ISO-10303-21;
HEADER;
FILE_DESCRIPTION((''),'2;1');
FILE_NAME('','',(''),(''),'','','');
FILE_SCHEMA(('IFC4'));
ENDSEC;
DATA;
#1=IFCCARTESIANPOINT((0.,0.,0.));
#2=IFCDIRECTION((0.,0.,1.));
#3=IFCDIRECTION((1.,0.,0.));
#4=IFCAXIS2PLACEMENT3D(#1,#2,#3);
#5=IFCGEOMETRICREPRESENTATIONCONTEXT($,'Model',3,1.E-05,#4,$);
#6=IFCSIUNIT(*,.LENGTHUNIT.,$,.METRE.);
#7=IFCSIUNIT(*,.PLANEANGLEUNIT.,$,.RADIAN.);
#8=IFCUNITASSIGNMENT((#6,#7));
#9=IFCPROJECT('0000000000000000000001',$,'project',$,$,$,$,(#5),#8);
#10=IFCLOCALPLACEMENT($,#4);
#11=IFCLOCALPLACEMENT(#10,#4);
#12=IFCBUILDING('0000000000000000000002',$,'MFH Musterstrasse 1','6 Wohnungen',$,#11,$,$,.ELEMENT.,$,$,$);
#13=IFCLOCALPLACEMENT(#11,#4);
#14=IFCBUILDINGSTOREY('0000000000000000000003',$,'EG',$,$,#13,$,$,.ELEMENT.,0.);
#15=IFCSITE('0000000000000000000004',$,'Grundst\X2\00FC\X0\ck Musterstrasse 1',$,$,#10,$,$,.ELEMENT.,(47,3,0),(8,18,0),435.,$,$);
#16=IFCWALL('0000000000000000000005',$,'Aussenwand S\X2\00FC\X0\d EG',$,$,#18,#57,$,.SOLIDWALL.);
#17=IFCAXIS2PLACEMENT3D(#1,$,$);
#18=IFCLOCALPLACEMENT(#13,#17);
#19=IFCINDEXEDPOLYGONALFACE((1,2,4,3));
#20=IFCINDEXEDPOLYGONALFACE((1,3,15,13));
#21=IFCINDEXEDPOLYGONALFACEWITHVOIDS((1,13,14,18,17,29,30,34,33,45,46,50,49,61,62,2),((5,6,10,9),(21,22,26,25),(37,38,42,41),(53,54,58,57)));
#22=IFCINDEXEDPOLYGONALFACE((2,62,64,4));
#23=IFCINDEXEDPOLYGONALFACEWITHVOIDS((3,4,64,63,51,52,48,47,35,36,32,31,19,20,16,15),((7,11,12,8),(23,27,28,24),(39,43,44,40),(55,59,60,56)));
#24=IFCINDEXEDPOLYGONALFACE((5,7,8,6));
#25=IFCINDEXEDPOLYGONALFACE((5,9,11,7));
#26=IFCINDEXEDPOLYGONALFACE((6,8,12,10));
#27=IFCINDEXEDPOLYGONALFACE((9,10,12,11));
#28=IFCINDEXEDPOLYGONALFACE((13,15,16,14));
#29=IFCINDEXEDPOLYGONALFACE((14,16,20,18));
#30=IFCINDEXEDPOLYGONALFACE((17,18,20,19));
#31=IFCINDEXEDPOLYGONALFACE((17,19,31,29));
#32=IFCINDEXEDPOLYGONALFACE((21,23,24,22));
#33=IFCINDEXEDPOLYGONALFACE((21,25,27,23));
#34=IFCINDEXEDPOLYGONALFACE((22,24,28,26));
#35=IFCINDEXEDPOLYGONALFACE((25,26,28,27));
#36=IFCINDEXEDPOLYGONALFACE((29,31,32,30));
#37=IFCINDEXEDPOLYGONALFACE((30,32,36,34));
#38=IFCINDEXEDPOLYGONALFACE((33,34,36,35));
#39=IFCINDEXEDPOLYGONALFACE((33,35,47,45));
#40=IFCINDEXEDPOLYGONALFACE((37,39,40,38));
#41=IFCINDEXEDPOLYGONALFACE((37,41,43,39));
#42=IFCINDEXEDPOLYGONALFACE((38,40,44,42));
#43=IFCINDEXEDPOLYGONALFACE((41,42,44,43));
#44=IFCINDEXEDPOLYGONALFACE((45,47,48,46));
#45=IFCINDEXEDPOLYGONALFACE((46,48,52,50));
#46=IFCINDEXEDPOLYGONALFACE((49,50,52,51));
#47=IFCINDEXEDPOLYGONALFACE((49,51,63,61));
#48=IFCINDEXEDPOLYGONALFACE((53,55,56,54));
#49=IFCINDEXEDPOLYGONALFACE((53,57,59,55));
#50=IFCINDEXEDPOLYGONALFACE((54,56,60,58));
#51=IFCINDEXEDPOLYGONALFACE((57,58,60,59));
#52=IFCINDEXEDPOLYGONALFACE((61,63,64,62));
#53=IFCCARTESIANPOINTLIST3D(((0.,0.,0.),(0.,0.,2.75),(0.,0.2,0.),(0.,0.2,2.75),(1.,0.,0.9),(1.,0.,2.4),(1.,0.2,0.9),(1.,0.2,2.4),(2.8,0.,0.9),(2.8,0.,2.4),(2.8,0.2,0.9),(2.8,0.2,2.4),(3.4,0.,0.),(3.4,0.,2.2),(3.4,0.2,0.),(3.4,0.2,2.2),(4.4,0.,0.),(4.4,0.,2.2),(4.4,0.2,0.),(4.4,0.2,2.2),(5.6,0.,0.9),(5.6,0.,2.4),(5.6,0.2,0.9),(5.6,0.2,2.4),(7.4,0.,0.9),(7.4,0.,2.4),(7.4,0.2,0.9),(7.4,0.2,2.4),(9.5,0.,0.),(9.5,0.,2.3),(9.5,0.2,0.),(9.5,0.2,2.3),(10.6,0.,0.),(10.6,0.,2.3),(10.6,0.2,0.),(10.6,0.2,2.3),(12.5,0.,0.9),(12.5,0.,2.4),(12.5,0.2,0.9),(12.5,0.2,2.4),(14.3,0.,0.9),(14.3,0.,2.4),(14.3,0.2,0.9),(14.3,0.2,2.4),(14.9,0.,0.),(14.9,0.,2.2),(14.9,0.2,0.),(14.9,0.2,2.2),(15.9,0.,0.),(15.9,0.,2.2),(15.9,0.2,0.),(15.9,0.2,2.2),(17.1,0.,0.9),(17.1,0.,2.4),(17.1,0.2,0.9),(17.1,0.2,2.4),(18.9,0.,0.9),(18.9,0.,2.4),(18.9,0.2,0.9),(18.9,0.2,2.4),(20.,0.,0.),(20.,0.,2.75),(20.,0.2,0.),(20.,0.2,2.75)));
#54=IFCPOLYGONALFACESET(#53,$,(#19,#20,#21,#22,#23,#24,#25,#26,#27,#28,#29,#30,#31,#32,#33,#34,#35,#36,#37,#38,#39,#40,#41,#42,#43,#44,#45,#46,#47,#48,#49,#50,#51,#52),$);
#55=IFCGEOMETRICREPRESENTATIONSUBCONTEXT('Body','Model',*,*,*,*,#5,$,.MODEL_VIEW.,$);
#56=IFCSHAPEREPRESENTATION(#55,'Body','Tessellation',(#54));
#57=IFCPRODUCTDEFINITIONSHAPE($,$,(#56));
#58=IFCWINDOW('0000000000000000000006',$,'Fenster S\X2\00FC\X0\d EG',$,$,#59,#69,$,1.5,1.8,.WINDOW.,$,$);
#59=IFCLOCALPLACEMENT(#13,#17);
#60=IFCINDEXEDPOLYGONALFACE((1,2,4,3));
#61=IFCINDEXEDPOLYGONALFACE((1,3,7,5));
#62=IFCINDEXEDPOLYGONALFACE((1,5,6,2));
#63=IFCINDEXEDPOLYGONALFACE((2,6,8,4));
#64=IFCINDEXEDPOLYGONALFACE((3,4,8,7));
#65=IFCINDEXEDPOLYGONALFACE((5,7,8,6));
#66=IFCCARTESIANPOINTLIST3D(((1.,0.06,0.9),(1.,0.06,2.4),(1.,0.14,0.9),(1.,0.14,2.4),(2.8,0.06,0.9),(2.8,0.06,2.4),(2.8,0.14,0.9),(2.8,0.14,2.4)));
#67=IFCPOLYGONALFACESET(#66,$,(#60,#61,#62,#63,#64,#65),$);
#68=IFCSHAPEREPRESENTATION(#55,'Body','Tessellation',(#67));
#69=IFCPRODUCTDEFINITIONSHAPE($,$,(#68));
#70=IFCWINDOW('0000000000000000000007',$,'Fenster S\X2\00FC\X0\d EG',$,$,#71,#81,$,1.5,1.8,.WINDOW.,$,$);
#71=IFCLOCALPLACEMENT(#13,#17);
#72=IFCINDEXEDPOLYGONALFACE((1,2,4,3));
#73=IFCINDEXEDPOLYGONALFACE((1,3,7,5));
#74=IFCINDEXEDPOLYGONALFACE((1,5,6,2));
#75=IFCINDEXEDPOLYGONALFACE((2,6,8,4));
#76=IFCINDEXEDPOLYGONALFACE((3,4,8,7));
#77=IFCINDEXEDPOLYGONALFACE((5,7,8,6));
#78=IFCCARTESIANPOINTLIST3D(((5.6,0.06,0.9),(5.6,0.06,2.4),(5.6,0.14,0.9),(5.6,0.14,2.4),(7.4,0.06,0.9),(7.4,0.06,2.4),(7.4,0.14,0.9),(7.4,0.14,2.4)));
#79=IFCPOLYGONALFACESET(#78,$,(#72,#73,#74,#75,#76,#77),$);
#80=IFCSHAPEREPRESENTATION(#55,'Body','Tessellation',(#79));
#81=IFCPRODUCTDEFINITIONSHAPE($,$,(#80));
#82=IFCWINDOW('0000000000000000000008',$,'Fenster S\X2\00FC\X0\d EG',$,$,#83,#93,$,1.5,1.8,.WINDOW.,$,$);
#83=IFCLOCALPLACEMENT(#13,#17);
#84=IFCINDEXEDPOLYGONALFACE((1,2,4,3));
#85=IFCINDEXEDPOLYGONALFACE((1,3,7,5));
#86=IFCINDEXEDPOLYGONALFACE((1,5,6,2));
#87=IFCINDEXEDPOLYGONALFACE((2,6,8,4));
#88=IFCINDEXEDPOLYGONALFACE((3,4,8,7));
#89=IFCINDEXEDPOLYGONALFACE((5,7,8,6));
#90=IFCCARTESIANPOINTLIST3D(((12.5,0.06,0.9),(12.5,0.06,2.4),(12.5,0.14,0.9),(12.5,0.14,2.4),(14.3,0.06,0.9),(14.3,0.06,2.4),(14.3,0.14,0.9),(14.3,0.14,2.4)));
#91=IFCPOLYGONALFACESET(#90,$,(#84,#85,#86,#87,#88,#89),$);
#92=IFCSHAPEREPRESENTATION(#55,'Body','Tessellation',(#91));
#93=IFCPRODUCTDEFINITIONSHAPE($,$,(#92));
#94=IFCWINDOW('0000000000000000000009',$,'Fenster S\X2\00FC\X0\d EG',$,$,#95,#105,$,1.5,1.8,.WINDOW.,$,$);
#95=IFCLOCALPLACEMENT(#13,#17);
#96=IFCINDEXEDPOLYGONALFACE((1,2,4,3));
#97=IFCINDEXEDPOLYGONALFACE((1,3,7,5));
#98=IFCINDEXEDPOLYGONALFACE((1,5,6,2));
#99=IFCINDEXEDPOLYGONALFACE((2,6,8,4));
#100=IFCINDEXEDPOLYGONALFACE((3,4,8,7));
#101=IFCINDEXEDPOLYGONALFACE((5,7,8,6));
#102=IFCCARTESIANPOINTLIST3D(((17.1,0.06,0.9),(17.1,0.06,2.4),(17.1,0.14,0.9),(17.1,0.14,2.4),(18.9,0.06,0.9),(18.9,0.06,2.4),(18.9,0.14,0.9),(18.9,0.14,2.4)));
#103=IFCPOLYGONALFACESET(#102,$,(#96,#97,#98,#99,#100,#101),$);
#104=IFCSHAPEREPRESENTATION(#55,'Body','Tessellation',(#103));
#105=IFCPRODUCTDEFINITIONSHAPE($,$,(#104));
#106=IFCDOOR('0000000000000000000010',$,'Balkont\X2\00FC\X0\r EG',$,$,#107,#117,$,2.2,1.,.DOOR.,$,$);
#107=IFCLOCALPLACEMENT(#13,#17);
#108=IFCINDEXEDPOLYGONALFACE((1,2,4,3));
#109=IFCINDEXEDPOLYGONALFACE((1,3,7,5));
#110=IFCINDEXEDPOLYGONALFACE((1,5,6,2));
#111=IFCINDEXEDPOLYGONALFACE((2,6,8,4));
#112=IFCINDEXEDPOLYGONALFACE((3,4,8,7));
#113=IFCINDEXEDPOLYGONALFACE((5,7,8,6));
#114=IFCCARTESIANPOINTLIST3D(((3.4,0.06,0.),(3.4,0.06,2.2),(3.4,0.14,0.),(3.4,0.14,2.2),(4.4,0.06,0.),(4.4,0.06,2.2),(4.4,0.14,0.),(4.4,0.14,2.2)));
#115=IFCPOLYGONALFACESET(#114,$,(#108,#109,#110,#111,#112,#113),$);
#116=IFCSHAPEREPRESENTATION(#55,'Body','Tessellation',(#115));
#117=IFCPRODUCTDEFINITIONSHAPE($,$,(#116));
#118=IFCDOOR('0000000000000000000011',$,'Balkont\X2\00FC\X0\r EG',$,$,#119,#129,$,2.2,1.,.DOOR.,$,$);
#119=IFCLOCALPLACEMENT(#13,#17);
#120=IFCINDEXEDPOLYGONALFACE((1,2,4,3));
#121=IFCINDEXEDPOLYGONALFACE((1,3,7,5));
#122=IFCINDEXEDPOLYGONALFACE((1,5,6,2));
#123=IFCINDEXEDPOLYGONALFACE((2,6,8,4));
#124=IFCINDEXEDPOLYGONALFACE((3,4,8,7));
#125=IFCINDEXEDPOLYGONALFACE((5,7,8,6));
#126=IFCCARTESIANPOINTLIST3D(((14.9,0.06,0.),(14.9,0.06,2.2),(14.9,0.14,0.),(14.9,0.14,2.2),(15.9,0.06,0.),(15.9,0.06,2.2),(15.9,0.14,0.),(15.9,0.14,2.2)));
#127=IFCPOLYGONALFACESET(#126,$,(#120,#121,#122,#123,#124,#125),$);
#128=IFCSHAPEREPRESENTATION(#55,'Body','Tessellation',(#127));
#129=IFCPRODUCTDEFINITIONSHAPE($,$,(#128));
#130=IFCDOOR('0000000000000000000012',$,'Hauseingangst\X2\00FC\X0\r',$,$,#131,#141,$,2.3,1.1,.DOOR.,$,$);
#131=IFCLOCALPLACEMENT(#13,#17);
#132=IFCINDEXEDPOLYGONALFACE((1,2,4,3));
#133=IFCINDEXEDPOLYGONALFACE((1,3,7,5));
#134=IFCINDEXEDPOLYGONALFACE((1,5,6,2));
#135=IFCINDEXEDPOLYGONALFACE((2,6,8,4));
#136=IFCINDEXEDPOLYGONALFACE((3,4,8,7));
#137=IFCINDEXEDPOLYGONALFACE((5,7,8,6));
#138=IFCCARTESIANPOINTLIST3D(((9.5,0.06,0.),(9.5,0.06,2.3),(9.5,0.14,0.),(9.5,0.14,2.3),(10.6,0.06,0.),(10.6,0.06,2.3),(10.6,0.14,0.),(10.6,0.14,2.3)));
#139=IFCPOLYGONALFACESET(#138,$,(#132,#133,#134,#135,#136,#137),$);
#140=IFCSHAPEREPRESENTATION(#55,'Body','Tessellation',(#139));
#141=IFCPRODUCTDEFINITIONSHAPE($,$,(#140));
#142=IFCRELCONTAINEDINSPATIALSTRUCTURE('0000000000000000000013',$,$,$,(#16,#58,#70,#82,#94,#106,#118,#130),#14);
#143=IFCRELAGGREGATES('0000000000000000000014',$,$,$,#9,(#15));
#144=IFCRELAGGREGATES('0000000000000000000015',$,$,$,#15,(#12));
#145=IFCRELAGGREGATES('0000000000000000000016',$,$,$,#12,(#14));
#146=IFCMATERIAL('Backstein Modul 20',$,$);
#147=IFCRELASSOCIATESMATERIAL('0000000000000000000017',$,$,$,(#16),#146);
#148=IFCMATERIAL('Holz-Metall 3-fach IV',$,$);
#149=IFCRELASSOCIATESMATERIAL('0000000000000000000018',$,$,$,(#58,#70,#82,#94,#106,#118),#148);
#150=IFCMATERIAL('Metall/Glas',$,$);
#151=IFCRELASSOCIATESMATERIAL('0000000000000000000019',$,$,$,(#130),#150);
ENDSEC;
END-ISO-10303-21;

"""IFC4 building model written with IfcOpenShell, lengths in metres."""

from ifc_helpers import new_model, si_unit, frame, frame_2d, origin_with_axes, place, context, subcontext, project, spatial, rectangle, extrude, material, element, fill, save


model = new_model("IFC4")

# Units and contexts
model_context = context("Model", 3, precision=1e-05, world=origin_with_axes())
body_context = subcontext(model_context, "Body", "Model", "MODEL_VIEW")
ifc_project = project(units=[si_unit("LENGTHUNIT", "METRE"), si_unit("PLANEANGLEUNIT", "RADIAN")], contexts=[model_context])

# Site, building, storey
site_placement = place(None, origin_with_axes())
site = spatial("IfcSite", under=ifc_project, at=site_placement, Name="Grundstück Musterstrasse 1", CompositionType="ELEMENT", RefLatitude=(47, 3, 0), RefLongitude=(8, 18, 0), RefElevation=435.0)
building_placement = place(site_placement, origin_with_axes())
building = spatial("IfcBuilding", under=site, at=building_placement, Name="MFH Musterstrasse 1", Description="6 Wohnungen", CompositionType="ELEMENT")
storey_placement = place(building_placement, origin_with_axes())
storey = spatial("IfcBuildingStorey", under=building, at=storey_placement, Name="EG", CompositionType="ELEMENT", Elevation=0.0)

# Wall, openings, windows, doors
ifc_material_1 = material(Name="Backstein Modul 20")
wall_1_placement = place(storey_placement, origin_with_axes())
wall_1 = element("IfcWall", 1, at=wall_1_placement, inside=storey, material=ifc_material_1, Name="Aussenwand Süd EG", PredefinedType="SOLIDWALL", context=body_context, shape_type="SweptSolid", body=[
    extrude(rectangle(XDim=20.0, YDim=0.2, at=frame_2d((10.0, 0.1), x_axis=(1.0, 0.0))), origin_with_axes(), (0.0, 0.0, 1.0), 2.75),
])
opening_1_placement = place(storey_placement, origin_with_axes())
element("IfcOpeningElement", 2, at=opening_1_placement, cuts=wall_1, PredefinedType="OPENING", context=body_context, shape_type="SweptSolid", body=[
    extrude(rectangle(XDim=1.8, YDim=0.3, at=frame_2d((0.9, 0.15), x_axis=(1.0, 0.0))), frame((1.0, -0.05, 0.9), z_axis=(0.0, 0.0, 1.0), x_axis=(1.0, 0.0, 0.0)), (0.0, 0.0, 1.0), 1.5),
])
opening_2_placement = place(storey_placement, origin_with_axes())
element("IfcOpeningElement", 3, at=opening_2_placement, cuts=wall_1, PredefinedType="OPENING", context=body_context, shape_type="SweptSolid", body=[
    extrude(rectangle(XDim=1.8, YDim=0.3, at=frame_2d((0.9, 0.15), x_axis=(1.0, 0.0))), frame((5.6, -0.05, 0.9), z_axis=(0.0, 0.0, 1.0), x_axis=(1.0, 0.0, 0.0)), (0.0, 0.0, 1.0), 1.5),
])
opening_3_placement = place(storey_placement, origin_with_axes())
element("IfcOpeningElement", 4, at=opening_3_placement, cuts=wall_1, PredefinedType="OPENING", context=body_context, shape_type="SweptSolid", body=[
    extrude(rectangle(XDim=1.8, YDim=0.3, at=frame_2d((0.9, 0.15), x_axis=(1.0, 0.0))), frame((12.5, -0.05, 0.9), z_axis=(0.0, 0.0, 1.0), x_axis=(1.0, 0.0, 0.0)), (0.0, 0.0, 1.0), 1.5),
])
opening_4_placement = place(storey_placement, origin_with_axes())
element("IfcOpeningElement", 5, at=opening_4_placement, cuts=wall_1, PredefinedType="OPENING", context=body_context, shape_type="SweptSolid", body=[
    extrude(rectangle(XDim=1.8, YDim=0.3, at=frame_2d((0.9, 0.15), x_axis=(1.0, 0.0))), frame((17.1, -0.05, 0.9), z_axis=(0.0, 0.0, 1.0), x_axis=(1.0, 0.0, 0.0)), (0.0, 0.0, 1.0), 1.5),
])
opening_5_placement = place(storey_placement, origin_with_axes())
element("IfcOpeningElement", 6, at=opening_5_placement, cuts=wall_1, PredefinedType="OPENING", context=body_context, shape_type="SweptSolid", body=[
    extrude(rectangle(XDim=1.0, YDim=0.3, at=frame_2d((0.5, 0.15), x_axis=(1.0, 0.0))), frame((3.4, -0.05, 0.0), z_axis=(0.0, 0.0, 1.0), x_axis=(1.0, 0.0, 0.0)), (0.0, 0.0, 1.0), 2.2),
])
opening_6_placement = place(storey_placement, origin_with_axes())
element("IfcOpeningElement", 7, at=opening_6_placement, cuts=wall_1, PredefinedType="OPENING", context=body_context, shape_type="SweptSolid", body=[
    extrude(rectangle(XDim=1.0, YDim=0.3, at=frame_2d((0.5, 0.15), x_axis=(1.0, 0.0))), frame((14.9, -0.05, 0.0), z_axis=(0.0, 0.0, 1.0), x_axis=(1.0, 0.0, 0.0)), (0.0, 0.0, 1.0), 2.2),
])
opening_7_placement = place(storey_placement, origin_with_axes())
element("IfcOpeningElement", 8, at=opening_7_placement, cuts=wall_1, PredefinedType="OPENING", context=body_context, shape_type="SweptSolid", body=[
    extrude(rectangle(XDim=1.1, YDim=0.3, at=frame_2d((0.55, 0.15), x_axis=(1.0, 0.0))), frame((9.5, -0.05, 0.0), z_axis=(0.0, 0.0, 1.0), x_axis=(1.0, 0.0, 0.0)), (0.0, 0.0, 1.0), 2.3),
])
opening_8_placement = place(storey_placement, origin_with_axes())
opening_8 = element("IfcOpeningElement", 9, at=opening_8_placement, cuts=wall_1, PredefinedType="OPENING", context=body_context, shape_type="SweptSolid", body=[
    extrude(rectangle(XDim=1.8, YDim=0.22, at=frame_2d((0.9, 0.11), x_axis=(1.0, 0.0))), frame((1.0, -0.01, 0.9), z_axis=(0.0, 0.0, 1.0), x_axis=(1.0, 0.0, 0.0)), (0.0, 0.0, 1.0), 1.5),
])
opening_9_placement = place(storey_placement, origin_with_axes())
opening_9 = element("IfcOpeningElement", 10, at=opening_9_placement, cuts=wall_1, PredefinedType="OPENING", context=body_context, shape_type="SweptSolid", body=[
    extrude(rectangle(XDim=1.8, YDim=0.22, at=frame_2d((0.9, 0.11), x_axis=(1.0, 0.0))), frame((5.6, -0.01, 0.9), z_axis=(0.0, 0.0, 1.0), x_axis=(1.0, 0.0, 0.0)), (0.0, 0.0, 1.0), 1.5),
])
opening_10_placement = place(storey_placement, origin_with_axes())
opening_10 = element("IfcOpeningElement", 11, at=opening_10_placement, cuts=wall_1, PredefinedType="OPENING", context=body_context, shape_type="SweptSolid", body=[
    extrude(rectangle(XDim=1.8, YDim=0.22, at=frame_2d((0.9, 0.11), x_axis=(1.0, 0.0))), frame((12.5, -0.01, 0.9), z_axis=(0.0, 0.0, 1.0), x_axis=(1.0, 0.0, 0.0)), (0.0, 0.0, 1.0), 1.5),
])
opening_11_placement = place(storey_placement, origin_with_axes())
opening_11 = element("IfcOpeningElement", 12, at=opening_11_placement, cuts=wall_1, PredefinedType="OPENING", context=body_context, shape_type="SweptSolid", body=[
    extrude(rectangle(XDim=1.8, YDim=0.22, at=frame_2d((0.9, 0.11), x_axis=(1.0, 0.0))), frame((17.1, -0.01, 0.9), z_axis=(0.0, 0.0, 1.0), x_axis=(1.0, 0.0, 0.0)), (0.0, 0.0, 1.0), 1.5),
])
opening_12_placement = place(storey_placement, origin_with_axes())
opening_12 = element("IfcOpeningElement", 13, at=opening_12_placement, cuts=wall_1, PredefinedType="OPENING", context=body_context, shape_type="SweptSolid", body=[
    extrude(rectangle(XDim=1.0, YDim=0.22, at=frame_2d((0.5, 0.11), x_axis=(1.0, 0.0))), frame((3.4, -0.01, 0.0), z_axis=(0.0, 0.0, 1.0), x_axis=(1.0, 0.0, 0.0)), (0.0, 0.0, 1.0), 2.2),
])
opening_13_placement = place(storey_placement, origin_with_axes())
opening_13 = element("IfcOpeningElement", 14, at=opening_13_placement, cuts=wall_1, PredefinedType="OPENING", context=body_context, shape_type="SweptSolid", body=[
    extrude(rectangle(XDim=1.0, YDim=0.22, at=frame_2d((0.5, 0.11), x_axis=(1.0, 0.0))), frame((14.9, -0.01, 0.0), z_axis=(0.0, 0.0, 1.0), x_axis=(1.0, 0.0, 0.0)), (0.0, 0.0, 1.0), 2.2),
])
opening_14_placement = place(storey_placement, origin_with_axes())
opening_14 = element("IfcOpeningElement", 15, at=opening_14_placement, cuts=wall_1, PredefinedType="OPENING", context=body_context, shape_type="SweptSolid", body=[
    extrude(rectangle(XDim=1.1, YDim=0.22, at=frame_2d((0.55, 0.11), x_axis=(1.0, 0.0))), frame((9.5, -0.01, 0.0), z_axis=(0.0, 0.0, 1.0), x_axis=(1.0, 0.0, 0.0)), (0.0, 0.0, 1.0), 2.3),
])
ifc_material_2 = material(Name="Holz-Metall 3-fach IV")
window_1_placement = place(storey_placement, origin_with_axes())
window_1 = element("IfcWindow", 16, at=window_1_placement, inside=storey, material=ifc_material_2, Name="Fenster Süd EG", OverallHeight=1.5, OverallWidth=1.8, PredefinedType="WINDOW", context=body_context, shape_type="SweptSolid", body=[
    extrude(rectangle(XDim=1.8, YDim=0.08, at=frame_2d((0.9, 0.04), x_axis=(1.0, 0.0))), frame((1.0, 0.06, 0.9), z_axis=(0.0, 0.0, 1.0), x_axis=(1.0, 0.0, 0.0)), (0.0, 0.0, 1.0), 1.5),
])
fill(opening_8, window_1)
window_2_placement = place(storey_placement, origin_with_axes())
window_2 = element("IfcWindow", 17, at=window_2_placement, inside=storey, material=ifc_material_2, Name="Fenster Süd EG", OverallHeight=1.5, OverallWidth=1.8, PredefinedType="WINDOW", context=body_context, shape_type="SweptSolid", body=[
    extrude(rectangle(XDim=1.8, YDim=0.08, at=frame_2d((0.9, 0.04), x_axis=(1.0, 0.0))), frame((5.6, 0.06, 0.9), z_axis=(0.0, 0.0, 1.0), x_axis=(1.0, 0.0, 0.0)), (0.0, 0.0, 1.0), 1.5),
])
fill(opening_9, window_2)
window_3_placement = place(storey_placement, origin_with_axes())
window_3 = element("IfcWindow", 18, at=window_3_placement, inside=storey, material=ifc_material_2, Name="Fenster Süd EG", OverallHeight=1.5, OverallWidth=1.8, PredefinedType="WINDOW", context=body_context, shape_type="SweptSolid", body=[
    extrude(rectangle(XDim=1.8, YDim=0.08, at=frame_2d((0.9, 0.04), x_axis=(1.0, 0.0))), frame((12.5, 0.06, 0.9), z_axis=(0.0, 0.0, 1.0), x_axis=(1.0, 0.0, 0.0)), (0.0, 0.0, 1.0), 1.5),
])
fill(opening_10, window_3)
window_4_placement = place(storey_placement, origin_with_axes())
window_4 = element("IfcWindow", 19, at=window_4_placement, inside=storey, material=ifc_material_2, Name="Fenster Süd EG", OverallHeight=1.5, OverallWidth=1.8, PredefinedType="WINDOW", context=body_context, shape_type="SweptSolid", body=[
    extrude(rectangle(XDim=1.8, YDim=0.08, at=frame_2d((0.9, 0.04), x_axis=(1.0, 0.0))), frame((17.1, 0.06, 0.9), z_axis=(0.0, 0.0, 1.0), x_axis=(1.0, 0.0, 0.0)), (0.0, 0.0, 1.0), 1.5),
])
fill(opening_11, window_4)
door_1_placement = place(storey_placement, origin_with_axes())
door_1 = element("IfcDoor", 20, at=door_1_placement, inside=storey, material=ifc_material_2, Name="Balkontür EG", OverallHeight=2.2, OverallWidth=1.0, PredefinedType="DOOR", context=body_context, shape_type="SweptSolid", body=[
    extrude(rectangle(XDim=1.0, YDim=0.08, at=frame_2d((0.5, 0.04), x_axis=(1.0, 0.0))), frame((3.4, 0.06, 0.0), z_axis=(0.0, 0.0, 1.0), x_axis=(1.0, 0.0, 0.0)), (0.0, 0.0, 1.0), 2.2),
])
fill(opening_12, door_1)
door_2_placement = place(storey_placement, origin_with_axes())
door_2 = element("IfcDoor", 21, at=door_2_placement, inside=storey, material=ifc_material_2, Name="Balkontür EG", OverallHeight=2.2, OverallWidth=1.0, PredefinedType="DOOR", context=body_context, shape_type="SweptSolid", body=[
    extrude(rectangle(XDim=1.0, YDim=0.08, at=frame_2d((0.5, 0.04), x_axis=(1.0, 0.0))), frame((14.9, 0.06, 0.0), z_axis=(0.0, 0.0, 1.0), x_axis=(1.0, 0.0, 0.0)), (0.0, 0.0, 1.0), 2.2),
])
fill(opening_13, door_2)
ifc_material_3 = material(Name="Metall/Glas")
door_3_placement = place(storey_placement, origin_with_axes())
door_3 = element("IfcDoor", 22, at=door_3_placement, inside=storey, material=ifc_material_3, Name="Hauseingangstür", OverallHeight=2.3, OverallWidth=1.1, PredefinedType="DOOR", context=body_context, shape_type="SweptSolid", body=[
    extrude(rectangle(XDim=1.1, YDim=0.08, at=frame_2d((0.55, 0.04), x_axis=(1.0, 0.0))), frame((9.5, 0.06, 0.0), z_axis=(0.0, 0.0, 1.0), x_axis=(1.0, 0.0, 0.0)), (0.0, 0.0, 1.0), 2.3),
])
fill(opening_14, door_3)

save(model, "model.ifc")
